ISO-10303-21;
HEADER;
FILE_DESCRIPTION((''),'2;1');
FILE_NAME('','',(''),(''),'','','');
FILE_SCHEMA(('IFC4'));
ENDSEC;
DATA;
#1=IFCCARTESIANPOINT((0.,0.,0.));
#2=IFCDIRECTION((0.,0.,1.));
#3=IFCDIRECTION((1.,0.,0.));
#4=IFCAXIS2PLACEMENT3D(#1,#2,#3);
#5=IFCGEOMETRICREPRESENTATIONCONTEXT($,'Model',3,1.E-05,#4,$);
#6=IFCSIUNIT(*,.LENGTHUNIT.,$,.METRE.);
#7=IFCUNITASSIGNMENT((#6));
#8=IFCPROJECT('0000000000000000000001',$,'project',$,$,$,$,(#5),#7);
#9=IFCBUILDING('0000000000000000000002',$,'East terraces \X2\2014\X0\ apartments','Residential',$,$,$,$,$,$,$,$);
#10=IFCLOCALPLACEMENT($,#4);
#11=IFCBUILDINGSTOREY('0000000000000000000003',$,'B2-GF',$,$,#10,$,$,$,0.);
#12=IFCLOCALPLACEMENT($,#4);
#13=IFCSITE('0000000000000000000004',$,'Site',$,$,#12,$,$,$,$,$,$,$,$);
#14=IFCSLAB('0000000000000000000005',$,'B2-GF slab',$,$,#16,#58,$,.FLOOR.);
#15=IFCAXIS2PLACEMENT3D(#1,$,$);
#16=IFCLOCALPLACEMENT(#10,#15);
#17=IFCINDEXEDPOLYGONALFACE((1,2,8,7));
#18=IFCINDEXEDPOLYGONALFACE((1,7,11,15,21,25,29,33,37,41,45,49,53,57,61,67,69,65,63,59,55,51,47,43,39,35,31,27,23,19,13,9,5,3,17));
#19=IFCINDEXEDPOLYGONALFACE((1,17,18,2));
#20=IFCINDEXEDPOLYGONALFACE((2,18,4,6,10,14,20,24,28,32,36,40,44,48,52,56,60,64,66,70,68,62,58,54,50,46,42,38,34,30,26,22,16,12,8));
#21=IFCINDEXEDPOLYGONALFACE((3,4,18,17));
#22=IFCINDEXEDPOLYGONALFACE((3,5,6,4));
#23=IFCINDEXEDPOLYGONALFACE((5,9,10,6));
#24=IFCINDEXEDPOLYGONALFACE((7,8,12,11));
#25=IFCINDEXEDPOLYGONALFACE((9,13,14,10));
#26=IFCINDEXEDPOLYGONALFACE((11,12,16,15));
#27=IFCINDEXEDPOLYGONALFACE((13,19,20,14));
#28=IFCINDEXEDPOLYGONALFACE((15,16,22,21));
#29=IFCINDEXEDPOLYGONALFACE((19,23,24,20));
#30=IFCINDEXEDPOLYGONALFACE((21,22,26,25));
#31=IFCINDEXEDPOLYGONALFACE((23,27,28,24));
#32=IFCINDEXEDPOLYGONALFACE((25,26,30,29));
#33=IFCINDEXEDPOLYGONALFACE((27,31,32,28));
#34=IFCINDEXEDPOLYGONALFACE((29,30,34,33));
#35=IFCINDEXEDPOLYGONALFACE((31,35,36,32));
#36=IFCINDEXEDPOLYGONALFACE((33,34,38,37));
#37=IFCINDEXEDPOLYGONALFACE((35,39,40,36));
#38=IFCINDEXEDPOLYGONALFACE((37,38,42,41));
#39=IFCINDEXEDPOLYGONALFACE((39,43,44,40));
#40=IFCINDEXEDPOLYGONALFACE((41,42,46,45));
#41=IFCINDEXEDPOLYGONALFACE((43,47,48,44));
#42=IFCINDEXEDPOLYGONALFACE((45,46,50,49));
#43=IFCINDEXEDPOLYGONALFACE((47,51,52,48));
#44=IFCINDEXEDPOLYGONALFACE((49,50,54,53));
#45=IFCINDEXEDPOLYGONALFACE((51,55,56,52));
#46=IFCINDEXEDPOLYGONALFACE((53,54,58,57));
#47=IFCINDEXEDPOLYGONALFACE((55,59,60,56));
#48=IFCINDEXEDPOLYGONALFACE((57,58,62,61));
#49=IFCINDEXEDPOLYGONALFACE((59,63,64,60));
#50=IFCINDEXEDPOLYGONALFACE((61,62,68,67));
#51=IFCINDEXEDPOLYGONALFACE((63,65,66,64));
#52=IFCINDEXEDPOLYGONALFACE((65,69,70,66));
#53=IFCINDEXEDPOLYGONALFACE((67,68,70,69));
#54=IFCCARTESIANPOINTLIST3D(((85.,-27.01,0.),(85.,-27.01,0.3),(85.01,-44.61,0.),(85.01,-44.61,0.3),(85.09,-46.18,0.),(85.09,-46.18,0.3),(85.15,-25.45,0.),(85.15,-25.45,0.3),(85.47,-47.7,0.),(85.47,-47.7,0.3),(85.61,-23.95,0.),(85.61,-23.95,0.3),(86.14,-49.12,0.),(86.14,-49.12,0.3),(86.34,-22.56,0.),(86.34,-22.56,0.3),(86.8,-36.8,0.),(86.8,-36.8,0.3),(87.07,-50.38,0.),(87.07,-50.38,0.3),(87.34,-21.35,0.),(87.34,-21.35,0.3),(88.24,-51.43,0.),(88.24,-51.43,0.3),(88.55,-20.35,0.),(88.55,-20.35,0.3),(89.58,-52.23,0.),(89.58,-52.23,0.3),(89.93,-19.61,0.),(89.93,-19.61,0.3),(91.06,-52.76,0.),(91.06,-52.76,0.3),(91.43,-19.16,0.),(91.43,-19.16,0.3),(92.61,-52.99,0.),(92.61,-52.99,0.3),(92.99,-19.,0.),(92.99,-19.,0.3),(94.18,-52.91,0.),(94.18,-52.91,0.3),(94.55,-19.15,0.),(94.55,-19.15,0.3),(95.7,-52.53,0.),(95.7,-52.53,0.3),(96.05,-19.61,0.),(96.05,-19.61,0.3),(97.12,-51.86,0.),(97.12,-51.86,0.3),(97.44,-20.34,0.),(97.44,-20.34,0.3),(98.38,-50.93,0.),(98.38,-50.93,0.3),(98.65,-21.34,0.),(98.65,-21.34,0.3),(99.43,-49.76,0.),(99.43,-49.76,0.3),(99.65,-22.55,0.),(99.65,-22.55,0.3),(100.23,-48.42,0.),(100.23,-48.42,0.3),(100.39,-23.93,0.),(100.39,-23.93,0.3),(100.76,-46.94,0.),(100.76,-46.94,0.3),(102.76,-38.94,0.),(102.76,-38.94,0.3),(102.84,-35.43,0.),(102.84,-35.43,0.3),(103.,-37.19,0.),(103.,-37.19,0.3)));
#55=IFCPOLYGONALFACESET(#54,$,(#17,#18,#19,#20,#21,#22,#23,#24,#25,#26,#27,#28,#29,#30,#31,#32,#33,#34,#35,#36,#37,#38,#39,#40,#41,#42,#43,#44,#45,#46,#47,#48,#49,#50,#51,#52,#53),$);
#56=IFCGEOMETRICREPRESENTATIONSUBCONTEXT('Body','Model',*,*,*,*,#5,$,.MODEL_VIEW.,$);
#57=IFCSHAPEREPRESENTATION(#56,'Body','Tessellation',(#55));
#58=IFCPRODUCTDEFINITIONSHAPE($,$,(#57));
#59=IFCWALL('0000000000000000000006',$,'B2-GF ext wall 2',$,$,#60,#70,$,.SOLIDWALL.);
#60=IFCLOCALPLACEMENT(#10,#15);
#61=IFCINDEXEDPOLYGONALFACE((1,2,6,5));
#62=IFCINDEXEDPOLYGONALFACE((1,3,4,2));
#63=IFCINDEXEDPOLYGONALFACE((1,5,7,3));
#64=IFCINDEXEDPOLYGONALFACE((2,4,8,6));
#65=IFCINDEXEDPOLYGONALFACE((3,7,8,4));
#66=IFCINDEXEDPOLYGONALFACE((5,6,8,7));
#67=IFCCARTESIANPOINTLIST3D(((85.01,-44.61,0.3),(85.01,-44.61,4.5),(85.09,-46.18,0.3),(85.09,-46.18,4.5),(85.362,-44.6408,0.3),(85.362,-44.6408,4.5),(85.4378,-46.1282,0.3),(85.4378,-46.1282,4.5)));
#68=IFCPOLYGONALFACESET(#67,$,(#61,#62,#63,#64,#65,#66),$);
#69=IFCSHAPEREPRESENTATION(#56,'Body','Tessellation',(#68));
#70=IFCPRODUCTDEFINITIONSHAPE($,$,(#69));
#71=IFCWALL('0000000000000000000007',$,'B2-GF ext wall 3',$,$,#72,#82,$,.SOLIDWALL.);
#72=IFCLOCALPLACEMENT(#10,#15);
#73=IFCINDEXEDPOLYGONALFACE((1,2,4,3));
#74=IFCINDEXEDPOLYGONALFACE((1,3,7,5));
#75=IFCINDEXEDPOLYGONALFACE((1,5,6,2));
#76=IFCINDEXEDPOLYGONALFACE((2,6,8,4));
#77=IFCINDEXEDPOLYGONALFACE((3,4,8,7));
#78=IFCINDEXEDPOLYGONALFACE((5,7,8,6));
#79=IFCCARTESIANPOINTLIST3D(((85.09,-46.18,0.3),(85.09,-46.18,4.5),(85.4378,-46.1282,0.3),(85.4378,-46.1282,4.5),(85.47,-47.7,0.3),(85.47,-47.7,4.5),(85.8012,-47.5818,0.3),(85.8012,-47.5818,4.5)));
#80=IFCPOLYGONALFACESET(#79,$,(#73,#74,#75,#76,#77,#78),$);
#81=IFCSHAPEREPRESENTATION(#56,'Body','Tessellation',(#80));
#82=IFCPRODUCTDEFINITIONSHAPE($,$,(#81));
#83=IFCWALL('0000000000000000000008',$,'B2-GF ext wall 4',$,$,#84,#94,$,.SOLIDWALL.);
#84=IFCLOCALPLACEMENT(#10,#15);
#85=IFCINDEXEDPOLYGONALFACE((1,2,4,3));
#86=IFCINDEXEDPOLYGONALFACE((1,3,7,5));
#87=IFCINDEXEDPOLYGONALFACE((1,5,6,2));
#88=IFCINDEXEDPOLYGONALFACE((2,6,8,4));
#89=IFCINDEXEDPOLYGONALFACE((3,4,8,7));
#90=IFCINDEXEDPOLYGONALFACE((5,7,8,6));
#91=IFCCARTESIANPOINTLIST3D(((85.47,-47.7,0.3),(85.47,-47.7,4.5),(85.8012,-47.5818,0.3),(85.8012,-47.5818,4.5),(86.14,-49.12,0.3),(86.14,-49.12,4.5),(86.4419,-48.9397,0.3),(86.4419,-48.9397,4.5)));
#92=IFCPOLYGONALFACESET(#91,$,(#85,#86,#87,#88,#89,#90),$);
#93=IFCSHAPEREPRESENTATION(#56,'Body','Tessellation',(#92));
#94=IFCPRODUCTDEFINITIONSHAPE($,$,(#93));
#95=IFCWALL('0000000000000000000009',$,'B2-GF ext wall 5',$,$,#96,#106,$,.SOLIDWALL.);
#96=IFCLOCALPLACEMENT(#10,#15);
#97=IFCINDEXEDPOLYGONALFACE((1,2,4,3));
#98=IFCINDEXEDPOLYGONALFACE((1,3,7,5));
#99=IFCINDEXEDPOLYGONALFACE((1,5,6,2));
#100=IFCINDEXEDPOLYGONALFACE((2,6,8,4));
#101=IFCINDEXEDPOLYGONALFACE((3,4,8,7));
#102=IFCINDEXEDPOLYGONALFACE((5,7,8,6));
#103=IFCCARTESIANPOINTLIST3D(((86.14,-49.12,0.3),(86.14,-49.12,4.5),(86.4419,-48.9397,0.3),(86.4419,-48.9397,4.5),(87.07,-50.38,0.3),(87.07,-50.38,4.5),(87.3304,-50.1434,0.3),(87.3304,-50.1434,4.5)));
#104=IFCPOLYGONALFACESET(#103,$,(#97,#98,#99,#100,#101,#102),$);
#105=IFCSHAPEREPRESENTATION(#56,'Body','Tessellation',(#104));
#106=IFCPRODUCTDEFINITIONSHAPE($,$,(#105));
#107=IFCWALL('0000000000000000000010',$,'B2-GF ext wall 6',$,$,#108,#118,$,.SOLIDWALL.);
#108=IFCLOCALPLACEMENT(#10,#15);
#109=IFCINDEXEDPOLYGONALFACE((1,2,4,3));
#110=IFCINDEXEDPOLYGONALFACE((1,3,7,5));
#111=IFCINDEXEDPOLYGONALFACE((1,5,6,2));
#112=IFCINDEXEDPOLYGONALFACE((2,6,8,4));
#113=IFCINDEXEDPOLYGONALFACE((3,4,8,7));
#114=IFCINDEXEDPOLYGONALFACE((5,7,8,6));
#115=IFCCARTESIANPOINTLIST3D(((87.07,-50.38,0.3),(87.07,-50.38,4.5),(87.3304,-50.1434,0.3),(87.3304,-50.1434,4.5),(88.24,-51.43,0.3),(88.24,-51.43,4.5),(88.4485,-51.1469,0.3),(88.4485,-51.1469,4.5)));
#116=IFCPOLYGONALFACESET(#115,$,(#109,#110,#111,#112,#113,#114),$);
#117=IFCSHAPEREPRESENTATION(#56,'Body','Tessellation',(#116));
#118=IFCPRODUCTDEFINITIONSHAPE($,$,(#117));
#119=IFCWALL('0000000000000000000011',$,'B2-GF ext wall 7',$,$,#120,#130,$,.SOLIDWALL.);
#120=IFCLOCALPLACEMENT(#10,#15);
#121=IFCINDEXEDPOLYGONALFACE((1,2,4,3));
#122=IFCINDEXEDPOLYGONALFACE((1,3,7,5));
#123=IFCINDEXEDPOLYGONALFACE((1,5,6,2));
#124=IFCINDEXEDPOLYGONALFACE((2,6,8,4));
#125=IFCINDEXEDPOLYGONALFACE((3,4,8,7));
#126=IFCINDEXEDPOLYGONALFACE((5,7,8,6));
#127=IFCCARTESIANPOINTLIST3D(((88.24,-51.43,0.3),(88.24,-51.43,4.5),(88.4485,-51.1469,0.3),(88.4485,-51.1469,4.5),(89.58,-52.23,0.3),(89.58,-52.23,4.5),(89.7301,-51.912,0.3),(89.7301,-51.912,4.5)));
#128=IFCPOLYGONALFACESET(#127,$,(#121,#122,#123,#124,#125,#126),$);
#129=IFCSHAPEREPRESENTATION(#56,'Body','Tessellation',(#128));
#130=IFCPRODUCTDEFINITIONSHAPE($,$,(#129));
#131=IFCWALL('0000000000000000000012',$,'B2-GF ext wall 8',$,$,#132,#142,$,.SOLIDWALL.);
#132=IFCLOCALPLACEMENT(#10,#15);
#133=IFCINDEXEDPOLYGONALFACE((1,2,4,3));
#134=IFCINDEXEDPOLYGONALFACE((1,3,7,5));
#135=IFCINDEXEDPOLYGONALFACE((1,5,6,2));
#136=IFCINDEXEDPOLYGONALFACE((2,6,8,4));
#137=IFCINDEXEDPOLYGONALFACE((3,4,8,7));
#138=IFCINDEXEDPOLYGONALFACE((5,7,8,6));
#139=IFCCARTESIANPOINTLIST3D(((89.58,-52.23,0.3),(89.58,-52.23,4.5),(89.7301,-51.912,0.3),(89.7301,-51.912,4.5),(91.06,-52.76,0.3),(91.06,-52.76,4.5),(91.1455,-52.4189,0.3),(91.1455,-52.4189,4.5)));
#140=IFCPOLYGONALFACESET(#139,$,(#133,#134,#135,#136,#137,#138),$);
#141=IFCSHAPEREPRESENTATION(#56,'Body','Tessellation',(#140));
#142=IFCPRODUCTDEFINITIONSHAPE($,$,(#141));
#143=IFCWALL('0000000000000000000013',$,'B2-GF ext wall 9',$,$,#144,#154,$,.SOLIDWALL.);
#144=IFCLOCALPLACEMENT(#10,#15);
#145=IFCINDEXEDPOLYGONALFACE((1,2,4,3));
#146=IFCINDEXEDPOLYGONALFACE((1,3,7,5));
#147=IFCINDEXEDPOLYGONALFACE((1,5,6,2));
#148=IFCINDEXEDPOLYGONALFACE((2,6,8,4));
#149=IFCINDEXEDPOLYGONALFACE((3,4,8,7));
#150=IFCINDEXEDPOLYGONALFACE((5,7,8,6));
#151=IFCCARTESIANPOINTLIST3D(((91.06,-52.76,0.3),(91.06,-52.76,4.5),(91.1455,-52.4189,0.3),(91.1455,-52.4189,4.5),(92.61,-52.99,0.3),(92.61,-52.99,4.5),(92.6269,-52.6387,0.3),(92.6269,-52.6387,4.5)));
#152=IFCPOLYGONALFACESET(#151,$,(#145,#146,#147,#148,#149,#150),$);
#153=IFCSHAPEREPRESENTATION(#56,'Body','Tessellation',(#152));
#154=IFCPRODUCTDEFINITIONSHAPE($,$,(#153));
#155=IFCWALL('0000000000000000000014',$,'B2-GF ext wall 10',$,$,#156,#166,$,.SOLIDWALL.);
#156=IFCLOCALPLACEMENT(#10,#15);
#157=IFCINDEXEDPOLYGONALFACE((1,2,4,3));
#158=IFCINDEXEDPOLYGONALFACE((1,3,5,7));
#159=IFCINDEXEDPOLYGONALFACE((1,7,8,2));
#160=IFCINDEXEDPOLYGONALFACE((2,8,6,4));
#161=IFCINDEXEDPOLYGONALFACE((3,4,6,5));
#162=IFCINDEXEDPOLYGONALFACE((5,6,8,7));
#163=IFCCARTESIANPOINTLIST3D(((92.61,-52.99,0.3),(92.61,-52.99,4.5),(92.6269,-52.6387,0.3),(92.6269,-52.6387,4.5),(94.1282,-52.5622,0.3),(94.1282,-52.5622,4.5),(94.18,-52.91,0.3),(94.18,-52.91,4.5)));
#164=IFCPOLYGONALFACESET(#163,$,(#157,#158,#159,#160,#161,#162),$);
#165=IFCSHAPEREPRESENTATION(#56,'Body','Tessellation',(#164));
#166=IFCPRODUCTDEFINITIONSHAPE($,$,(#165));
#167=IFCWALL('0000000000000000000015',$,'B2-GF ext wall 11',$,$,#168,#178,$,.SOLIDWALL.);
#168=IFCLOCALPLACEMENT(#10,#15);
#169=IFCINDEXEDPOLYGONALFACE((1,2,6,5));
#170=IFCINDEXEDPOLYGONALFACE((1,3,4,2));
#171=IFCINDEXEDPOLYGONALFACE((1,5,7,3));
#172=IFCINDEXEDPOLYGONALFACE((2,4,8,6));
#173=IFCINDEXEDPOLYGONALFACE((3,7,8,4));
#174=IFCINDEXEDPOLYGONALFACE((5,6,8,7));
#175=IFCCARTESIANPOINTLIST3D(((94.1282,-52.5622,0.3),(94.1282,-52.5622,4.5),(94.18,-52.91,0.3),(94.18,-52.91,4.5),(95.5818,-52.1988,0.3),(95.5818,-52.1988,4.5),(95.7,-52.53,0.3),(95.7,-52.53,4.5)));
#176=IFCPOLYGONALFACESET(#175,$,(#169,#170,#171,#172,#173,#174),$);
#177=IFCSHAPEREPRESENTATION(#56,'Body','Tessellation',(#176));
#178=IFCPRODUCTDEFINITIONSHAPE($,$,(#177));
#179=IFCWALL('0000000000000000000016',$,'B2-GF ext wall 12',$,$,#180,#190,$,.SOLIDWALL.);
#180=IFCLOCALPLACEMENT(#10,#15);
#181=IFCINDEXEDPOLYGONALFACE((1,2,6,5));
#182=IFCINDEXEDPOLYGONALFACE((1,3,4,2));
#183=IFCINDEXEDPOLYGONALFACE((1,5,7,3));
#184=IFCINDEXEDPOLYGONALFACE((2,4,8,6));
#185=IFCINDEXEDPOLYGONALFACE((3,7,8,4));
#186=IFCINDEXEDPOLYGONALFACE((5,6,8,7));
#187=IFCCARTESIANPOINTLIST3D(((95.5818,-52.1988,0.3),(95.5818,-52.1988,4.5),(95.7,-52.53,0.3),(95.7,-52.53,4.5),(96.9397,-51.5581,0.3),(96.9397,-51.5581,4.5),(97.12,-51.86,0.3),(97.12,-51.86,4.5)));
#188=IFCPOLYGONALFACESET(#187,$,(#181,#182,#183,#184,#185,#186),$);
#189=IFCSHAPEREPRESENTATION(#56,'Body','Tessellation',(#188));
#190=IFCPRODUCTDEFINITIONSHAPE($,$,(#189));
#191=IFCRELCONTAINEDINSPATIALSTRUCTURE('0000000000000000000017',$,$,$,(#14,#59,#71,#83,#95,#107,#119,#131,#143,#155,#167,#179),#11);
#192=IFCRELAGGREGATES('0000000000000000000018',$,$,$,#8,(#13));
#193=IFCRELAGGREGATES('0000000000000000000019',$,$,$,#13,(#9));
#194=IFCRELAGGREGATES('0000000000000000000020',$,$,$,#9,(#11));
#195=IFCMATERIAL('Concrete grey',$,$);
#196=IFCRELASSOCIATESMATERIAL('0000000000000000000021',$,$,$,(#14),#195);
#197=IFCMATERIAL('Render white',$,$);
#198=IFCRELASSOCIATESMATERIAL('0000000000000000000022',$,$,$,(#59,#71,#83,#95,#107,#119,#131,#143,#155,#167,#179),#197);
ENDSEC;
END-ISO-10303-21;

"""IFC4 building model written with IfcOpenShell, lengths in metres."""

from ifc_helpers import new_model, si_unit, frame, origin_with_axes, place, context, subcontext, project, spatial, polyline, outline, extrude, material, element, save


model = new_model("IFC4")

# Units and contexts
model_context = context("Model", 3, precision=1e-05, world=origin_with_axes())
body_context = subcontext(model_context, "Body", "Model", "MODEL_VIEW")
ifc_project = project(units=[si_unit("LENGTHUNIT", "METRE")], contexts=[model_context])

# Site, building, storey
site_placement = place(None, origin_with_axes())
site = spatial("IfcSite", under=ifc_project, at=site_placement, Name="Site")
building = spatial("IfcBuilding", under=site, Name="East terraces — apartments", Description="Residential")
storey_placement = place(None, origin_with_axes())
storey = spatial("IfcBuildingStorey", under=building, at=storey_placement, Name="B2-GF", Elevation=0.0)

# Slab
ifc_material_1 = material(Name="Concrete grey")
slab_placement = place(storey_placement, origin_with_axes())
element("IfcSlab", 1, at=slab_placement, inside=storey, material=ifc_material_1, Name="B2-GF slab", PredefinedType="FLOOR", context=body_context, shape_type="SweptSolid", body=[
    extrude(outline(polyline([(86.8, -36.8), (85.01, -44.61), (85.09, -46.18), (85.47, -47.7), (86.14, -49.12), (87.07, -50.38), (88.24, -51.43), (89.58, -52.23), (91.06, -52.76), (92.61, -52.99), (94.18, -52.91), (95.7, -52.53), (97.12, -51.86), (98.38, -50.93), (99.43, -49.76), (100.23, -48.42), (100.76, -46.94), (102.76, -38.94), (103.0, -37.19), (102.84, -35.43), (100.39, -23.93), (99.65, -22.55), (98.65, -21.34), (97.44, -20.34), (96.05, -19.61), (94.55, -19.15), (92.99, -19.0), (91.43, -19.16), (89.93, -19.61), (88.55, -20.35), (87.34, -21.35), (86.34, -22.56), (85.61, -23.95), (85.15, -25.45), (85.0, -27.01), (86.8, -36.8)])), origin_with_axes(), (0.0, 0.0, 1.0), 0.3),
])

# Shared definitions
ifc_material_2 = material(Name="Render white")

# Walls
wall_1_placement = place(storey_placement, origin_with_axes())
element("IfcWall", 2, at=wall_1_placement, inside=storey, material=ifc_material_2, Name="B2-GF ext wall 2", PredefinedType="SOLIDWALL", context=body_context, shape_type="SweptSolid", body=[
    extrude(outline(polyline([(85.01, -44.61), (85.09, -46.18), (85.4378, -46.1282), (85.362, -44.6408), (85.01, -44.61)])), frame((0.0, 0.0, 0.3), z_axis=(0.0, 0.0, 1.0), x_axis=(1.0, 0.0, 0.0)), (0.0, 0.0, 1.0), 4.2),
])
wall_2_placement = place(storey_placement, origin_with_axes())
element("IfcWall", 3, at=wall_2_placement, inside=storey, material=ifc_material_2, Name="B2-GF ext wall 3", PredefinedType="SOLIDWALL", context=body_context, shape_type="SweptSolid", body=[
    extrude(outline(polyline([(85.09, -46.18), (85.47, -47.7), (85.8012, -47.5818), (85.4378, -46.1282), (85.09, -46.18)])), frame((0.0, 0.0, 0.3), z_axis=(0.0, 0.0, 1.0), x_axis=(1.0, 0.0, 0.0)), (0.0, 0.0, 1.0), 4.2),
])
wall_3_placement = place(storey_placement, origin_with_axes())
element("IfcWall", 4, at=wall_3_placement, inside=storey, material=ifc_material_2, Name="B2-GF ext wall 4", PredefinedType="SOLIDWALL", context=body_context, shape_type="SweptSolid", body=[
    extrude(outline(polyline([(85.47, -47.7), (86.14, -49.12), (86.4419, -48.9397), (85.8012, -47.5818), (85.47, -47.7)])), frame((0.0, 0.0, 0.3), z_axis=(0.0, 0.0, 1.0), x_axis=(1.0, 0.0, 0.0)), (0.0, 0.0, 1.0), 4.2),
])
wall_4_placement = place(storey_placement, origin_with_axes())
element("IfcWall", 5, at=wall_4_placement, inside=storey, material=ifc_material_2, Name="B2-GF ext wall 5", PredefinedType="SOLIDWALL", context=body_context, shape_type="SweptSolid", body=[
    extrude(outline(polyline([(86.14, -49.12), (87.07, -50.38), (87.3304, -50.1434), (86.4419, -48.9397), (86.14, -49.12)])), frame((0.0, 0.0, 0.3), z_axis=(0.0, 0.0, 1.0), x_axis=(1.0, 0.0, 0.0)), (0.0, 0.0, 1.0), 4.2),
])
wall_5_placement = place(storey_placement, origin_with_axes())
element("IfcWall", 6, at=wall_5_placement, inside=storey, material=ifc_material_2, Name="B2-GF ext wall 6", PredefinedType="SOLIDWALL", context=body_context, shape_type="SweptSolid", body=[
    extrude(outline(polyline([(87.07, -50.38), (88.24, -51.43), (88.4485, -51.1469), (87.3304, -50.1434), (87.07, -50.38)])), frame((0.0, 0.0, 0.3), z_axis=(0.0, 0.0, 1.0), x_axis=(1.0, 0.0, 0.0)), (0.0, 0.0, 1.0), 4.2),
])
wall_6_placement = place(storey_placement, origin_with_axes())
element("IfcWall", 7, at=wall_6_placement, inside=storey, material=ifc_material_2, Name="B2-GF ext wall 7", PredefinedType="SOLIDWALL", context=body_context, shape_type="SweptSolid", body=[
    extrude(outline(polyline([(88.24, -51.43), (89.58, -52.23), (89.7301, -51.912), (88.4485, -51.1469), (88.24, -51.43)])), frame((0.0, 0.0, 0.3), z_axis=(0.0, 0.0, 1.0), x_axis=(1.0, 0.0, 0.0)), (0.0, 0.0, 1.0), 4.2),
])
wall_7_placement = place(storey_placement, origin_with_axes())
element("IfcWall", 8, at=wall_7_placement, inside=storey, material=ifc_material_2, Name="B2-GF ext wall 8", PredefinedType="SOLIDWALL", context=body_context, shape_type="SweptSolid", body=[
    extrude(outline(polyline([(89.58, -52.23), (91.06, -52.76), (91.1455, -52.4189), (89.7301, -51.912), (89.58, -52.23)])), frame((0.0, 0.0, 0.3), z_axis=(0.0, 0.0, 1.0), x_axis=(1.0, 0.0, 0.0)), (0.0, 0.0, 1.0), 4.2),
])
wall_8_placement = place(storey_placement, origin_with_axes())
element("IfcWall", 9, at=wall_8_placement, inside=storey, material=ifc_material_2, Name="B2-GF ext wall 9", PredefinedType="SOLIDWALL", context=body_context, shape_type="SweptSolid", body=[
    extrude(outline(polyline([(91.06, -52.76), (92.61, -52.99), (92.6269, -52.6387), (91.1455, -52.4189), (91.06, -52.76)])), frame((0.0, 0.0, 0.3), z_axis=(0.0, 0.0, 1.0), x_axis=(1.0, 0.0, 0.0)), (0.0, 0.0, 1.0), 4.2),
])
wall_9_placement = place(storey_placement, origin_with_axes())
element("IfcWall", 10, at=wall_9_placement, inside=storey, material=ifc_material_2, Name="B2-GF ext wall 10", PredefinedType="SOLIDWALL", context=body_context, shape_type="SweptSolid", body=[
    extrude(outline(polyline([(92.61, -52.99), (94.18, -52.91), (94.1282, -52.5622), (92.6269, -52.6387), (92.61, -52.99)])), frame((0.0, 0.0, 0.3), z_axis=(0.0, 0.0, 1.0), x_axis=(1.0, 0.0, 0.0)), (0.0, 0.0, 1.0), 4.2),
])
wall_10_placement = place(storey_placement, origin_with_axes())
element("IfcWall", 11, at=wall_10_placement, inside=storey, material=ifc_material_2, Name="B2-GF ext wall 11", PredefinedType="SOLIDWALL", context=body_context, shape_type="SweptSolid", body=[
    extrude(outline(polyline([(94.18, -52.91), (95.7, -52.53), (95.5818, -52.1988), (94.1282, -52.5622), (94.18, -52.91)])), frame((0.0, 0.0, 0.3), z_axis=(0.0, 0.0, 1.0), x_axis=(1.0, 0.0, 0.0)), (0.0, 0.0, 1.0), 4.2),
])
wall_11_placement = place(storey_placement, origin_with_axes())
element("IfcWall", 12, at=wall_11_placement, inside=storey, material=ifc_material_2, Name="B2-GF ext wall 12", PredefinedType="SOLIDWALL", context=body_context, shape_type="SweptSolid", body=[
    extrude(outline(polyline([(95.7, -52.53), (97.12, -51.86), (96.9397, -51.5581), (95.5818, -52.1988), (95.7, -52.53)])), frame((0.0, 0.0, 0.3), z_axis=(0.0, 0.0, 1.0), x_axis=(1.0, 0.0, 0.0)), (0.0, 0.0, 1.0), 4.2),
])

save(model, "model.ifc")
